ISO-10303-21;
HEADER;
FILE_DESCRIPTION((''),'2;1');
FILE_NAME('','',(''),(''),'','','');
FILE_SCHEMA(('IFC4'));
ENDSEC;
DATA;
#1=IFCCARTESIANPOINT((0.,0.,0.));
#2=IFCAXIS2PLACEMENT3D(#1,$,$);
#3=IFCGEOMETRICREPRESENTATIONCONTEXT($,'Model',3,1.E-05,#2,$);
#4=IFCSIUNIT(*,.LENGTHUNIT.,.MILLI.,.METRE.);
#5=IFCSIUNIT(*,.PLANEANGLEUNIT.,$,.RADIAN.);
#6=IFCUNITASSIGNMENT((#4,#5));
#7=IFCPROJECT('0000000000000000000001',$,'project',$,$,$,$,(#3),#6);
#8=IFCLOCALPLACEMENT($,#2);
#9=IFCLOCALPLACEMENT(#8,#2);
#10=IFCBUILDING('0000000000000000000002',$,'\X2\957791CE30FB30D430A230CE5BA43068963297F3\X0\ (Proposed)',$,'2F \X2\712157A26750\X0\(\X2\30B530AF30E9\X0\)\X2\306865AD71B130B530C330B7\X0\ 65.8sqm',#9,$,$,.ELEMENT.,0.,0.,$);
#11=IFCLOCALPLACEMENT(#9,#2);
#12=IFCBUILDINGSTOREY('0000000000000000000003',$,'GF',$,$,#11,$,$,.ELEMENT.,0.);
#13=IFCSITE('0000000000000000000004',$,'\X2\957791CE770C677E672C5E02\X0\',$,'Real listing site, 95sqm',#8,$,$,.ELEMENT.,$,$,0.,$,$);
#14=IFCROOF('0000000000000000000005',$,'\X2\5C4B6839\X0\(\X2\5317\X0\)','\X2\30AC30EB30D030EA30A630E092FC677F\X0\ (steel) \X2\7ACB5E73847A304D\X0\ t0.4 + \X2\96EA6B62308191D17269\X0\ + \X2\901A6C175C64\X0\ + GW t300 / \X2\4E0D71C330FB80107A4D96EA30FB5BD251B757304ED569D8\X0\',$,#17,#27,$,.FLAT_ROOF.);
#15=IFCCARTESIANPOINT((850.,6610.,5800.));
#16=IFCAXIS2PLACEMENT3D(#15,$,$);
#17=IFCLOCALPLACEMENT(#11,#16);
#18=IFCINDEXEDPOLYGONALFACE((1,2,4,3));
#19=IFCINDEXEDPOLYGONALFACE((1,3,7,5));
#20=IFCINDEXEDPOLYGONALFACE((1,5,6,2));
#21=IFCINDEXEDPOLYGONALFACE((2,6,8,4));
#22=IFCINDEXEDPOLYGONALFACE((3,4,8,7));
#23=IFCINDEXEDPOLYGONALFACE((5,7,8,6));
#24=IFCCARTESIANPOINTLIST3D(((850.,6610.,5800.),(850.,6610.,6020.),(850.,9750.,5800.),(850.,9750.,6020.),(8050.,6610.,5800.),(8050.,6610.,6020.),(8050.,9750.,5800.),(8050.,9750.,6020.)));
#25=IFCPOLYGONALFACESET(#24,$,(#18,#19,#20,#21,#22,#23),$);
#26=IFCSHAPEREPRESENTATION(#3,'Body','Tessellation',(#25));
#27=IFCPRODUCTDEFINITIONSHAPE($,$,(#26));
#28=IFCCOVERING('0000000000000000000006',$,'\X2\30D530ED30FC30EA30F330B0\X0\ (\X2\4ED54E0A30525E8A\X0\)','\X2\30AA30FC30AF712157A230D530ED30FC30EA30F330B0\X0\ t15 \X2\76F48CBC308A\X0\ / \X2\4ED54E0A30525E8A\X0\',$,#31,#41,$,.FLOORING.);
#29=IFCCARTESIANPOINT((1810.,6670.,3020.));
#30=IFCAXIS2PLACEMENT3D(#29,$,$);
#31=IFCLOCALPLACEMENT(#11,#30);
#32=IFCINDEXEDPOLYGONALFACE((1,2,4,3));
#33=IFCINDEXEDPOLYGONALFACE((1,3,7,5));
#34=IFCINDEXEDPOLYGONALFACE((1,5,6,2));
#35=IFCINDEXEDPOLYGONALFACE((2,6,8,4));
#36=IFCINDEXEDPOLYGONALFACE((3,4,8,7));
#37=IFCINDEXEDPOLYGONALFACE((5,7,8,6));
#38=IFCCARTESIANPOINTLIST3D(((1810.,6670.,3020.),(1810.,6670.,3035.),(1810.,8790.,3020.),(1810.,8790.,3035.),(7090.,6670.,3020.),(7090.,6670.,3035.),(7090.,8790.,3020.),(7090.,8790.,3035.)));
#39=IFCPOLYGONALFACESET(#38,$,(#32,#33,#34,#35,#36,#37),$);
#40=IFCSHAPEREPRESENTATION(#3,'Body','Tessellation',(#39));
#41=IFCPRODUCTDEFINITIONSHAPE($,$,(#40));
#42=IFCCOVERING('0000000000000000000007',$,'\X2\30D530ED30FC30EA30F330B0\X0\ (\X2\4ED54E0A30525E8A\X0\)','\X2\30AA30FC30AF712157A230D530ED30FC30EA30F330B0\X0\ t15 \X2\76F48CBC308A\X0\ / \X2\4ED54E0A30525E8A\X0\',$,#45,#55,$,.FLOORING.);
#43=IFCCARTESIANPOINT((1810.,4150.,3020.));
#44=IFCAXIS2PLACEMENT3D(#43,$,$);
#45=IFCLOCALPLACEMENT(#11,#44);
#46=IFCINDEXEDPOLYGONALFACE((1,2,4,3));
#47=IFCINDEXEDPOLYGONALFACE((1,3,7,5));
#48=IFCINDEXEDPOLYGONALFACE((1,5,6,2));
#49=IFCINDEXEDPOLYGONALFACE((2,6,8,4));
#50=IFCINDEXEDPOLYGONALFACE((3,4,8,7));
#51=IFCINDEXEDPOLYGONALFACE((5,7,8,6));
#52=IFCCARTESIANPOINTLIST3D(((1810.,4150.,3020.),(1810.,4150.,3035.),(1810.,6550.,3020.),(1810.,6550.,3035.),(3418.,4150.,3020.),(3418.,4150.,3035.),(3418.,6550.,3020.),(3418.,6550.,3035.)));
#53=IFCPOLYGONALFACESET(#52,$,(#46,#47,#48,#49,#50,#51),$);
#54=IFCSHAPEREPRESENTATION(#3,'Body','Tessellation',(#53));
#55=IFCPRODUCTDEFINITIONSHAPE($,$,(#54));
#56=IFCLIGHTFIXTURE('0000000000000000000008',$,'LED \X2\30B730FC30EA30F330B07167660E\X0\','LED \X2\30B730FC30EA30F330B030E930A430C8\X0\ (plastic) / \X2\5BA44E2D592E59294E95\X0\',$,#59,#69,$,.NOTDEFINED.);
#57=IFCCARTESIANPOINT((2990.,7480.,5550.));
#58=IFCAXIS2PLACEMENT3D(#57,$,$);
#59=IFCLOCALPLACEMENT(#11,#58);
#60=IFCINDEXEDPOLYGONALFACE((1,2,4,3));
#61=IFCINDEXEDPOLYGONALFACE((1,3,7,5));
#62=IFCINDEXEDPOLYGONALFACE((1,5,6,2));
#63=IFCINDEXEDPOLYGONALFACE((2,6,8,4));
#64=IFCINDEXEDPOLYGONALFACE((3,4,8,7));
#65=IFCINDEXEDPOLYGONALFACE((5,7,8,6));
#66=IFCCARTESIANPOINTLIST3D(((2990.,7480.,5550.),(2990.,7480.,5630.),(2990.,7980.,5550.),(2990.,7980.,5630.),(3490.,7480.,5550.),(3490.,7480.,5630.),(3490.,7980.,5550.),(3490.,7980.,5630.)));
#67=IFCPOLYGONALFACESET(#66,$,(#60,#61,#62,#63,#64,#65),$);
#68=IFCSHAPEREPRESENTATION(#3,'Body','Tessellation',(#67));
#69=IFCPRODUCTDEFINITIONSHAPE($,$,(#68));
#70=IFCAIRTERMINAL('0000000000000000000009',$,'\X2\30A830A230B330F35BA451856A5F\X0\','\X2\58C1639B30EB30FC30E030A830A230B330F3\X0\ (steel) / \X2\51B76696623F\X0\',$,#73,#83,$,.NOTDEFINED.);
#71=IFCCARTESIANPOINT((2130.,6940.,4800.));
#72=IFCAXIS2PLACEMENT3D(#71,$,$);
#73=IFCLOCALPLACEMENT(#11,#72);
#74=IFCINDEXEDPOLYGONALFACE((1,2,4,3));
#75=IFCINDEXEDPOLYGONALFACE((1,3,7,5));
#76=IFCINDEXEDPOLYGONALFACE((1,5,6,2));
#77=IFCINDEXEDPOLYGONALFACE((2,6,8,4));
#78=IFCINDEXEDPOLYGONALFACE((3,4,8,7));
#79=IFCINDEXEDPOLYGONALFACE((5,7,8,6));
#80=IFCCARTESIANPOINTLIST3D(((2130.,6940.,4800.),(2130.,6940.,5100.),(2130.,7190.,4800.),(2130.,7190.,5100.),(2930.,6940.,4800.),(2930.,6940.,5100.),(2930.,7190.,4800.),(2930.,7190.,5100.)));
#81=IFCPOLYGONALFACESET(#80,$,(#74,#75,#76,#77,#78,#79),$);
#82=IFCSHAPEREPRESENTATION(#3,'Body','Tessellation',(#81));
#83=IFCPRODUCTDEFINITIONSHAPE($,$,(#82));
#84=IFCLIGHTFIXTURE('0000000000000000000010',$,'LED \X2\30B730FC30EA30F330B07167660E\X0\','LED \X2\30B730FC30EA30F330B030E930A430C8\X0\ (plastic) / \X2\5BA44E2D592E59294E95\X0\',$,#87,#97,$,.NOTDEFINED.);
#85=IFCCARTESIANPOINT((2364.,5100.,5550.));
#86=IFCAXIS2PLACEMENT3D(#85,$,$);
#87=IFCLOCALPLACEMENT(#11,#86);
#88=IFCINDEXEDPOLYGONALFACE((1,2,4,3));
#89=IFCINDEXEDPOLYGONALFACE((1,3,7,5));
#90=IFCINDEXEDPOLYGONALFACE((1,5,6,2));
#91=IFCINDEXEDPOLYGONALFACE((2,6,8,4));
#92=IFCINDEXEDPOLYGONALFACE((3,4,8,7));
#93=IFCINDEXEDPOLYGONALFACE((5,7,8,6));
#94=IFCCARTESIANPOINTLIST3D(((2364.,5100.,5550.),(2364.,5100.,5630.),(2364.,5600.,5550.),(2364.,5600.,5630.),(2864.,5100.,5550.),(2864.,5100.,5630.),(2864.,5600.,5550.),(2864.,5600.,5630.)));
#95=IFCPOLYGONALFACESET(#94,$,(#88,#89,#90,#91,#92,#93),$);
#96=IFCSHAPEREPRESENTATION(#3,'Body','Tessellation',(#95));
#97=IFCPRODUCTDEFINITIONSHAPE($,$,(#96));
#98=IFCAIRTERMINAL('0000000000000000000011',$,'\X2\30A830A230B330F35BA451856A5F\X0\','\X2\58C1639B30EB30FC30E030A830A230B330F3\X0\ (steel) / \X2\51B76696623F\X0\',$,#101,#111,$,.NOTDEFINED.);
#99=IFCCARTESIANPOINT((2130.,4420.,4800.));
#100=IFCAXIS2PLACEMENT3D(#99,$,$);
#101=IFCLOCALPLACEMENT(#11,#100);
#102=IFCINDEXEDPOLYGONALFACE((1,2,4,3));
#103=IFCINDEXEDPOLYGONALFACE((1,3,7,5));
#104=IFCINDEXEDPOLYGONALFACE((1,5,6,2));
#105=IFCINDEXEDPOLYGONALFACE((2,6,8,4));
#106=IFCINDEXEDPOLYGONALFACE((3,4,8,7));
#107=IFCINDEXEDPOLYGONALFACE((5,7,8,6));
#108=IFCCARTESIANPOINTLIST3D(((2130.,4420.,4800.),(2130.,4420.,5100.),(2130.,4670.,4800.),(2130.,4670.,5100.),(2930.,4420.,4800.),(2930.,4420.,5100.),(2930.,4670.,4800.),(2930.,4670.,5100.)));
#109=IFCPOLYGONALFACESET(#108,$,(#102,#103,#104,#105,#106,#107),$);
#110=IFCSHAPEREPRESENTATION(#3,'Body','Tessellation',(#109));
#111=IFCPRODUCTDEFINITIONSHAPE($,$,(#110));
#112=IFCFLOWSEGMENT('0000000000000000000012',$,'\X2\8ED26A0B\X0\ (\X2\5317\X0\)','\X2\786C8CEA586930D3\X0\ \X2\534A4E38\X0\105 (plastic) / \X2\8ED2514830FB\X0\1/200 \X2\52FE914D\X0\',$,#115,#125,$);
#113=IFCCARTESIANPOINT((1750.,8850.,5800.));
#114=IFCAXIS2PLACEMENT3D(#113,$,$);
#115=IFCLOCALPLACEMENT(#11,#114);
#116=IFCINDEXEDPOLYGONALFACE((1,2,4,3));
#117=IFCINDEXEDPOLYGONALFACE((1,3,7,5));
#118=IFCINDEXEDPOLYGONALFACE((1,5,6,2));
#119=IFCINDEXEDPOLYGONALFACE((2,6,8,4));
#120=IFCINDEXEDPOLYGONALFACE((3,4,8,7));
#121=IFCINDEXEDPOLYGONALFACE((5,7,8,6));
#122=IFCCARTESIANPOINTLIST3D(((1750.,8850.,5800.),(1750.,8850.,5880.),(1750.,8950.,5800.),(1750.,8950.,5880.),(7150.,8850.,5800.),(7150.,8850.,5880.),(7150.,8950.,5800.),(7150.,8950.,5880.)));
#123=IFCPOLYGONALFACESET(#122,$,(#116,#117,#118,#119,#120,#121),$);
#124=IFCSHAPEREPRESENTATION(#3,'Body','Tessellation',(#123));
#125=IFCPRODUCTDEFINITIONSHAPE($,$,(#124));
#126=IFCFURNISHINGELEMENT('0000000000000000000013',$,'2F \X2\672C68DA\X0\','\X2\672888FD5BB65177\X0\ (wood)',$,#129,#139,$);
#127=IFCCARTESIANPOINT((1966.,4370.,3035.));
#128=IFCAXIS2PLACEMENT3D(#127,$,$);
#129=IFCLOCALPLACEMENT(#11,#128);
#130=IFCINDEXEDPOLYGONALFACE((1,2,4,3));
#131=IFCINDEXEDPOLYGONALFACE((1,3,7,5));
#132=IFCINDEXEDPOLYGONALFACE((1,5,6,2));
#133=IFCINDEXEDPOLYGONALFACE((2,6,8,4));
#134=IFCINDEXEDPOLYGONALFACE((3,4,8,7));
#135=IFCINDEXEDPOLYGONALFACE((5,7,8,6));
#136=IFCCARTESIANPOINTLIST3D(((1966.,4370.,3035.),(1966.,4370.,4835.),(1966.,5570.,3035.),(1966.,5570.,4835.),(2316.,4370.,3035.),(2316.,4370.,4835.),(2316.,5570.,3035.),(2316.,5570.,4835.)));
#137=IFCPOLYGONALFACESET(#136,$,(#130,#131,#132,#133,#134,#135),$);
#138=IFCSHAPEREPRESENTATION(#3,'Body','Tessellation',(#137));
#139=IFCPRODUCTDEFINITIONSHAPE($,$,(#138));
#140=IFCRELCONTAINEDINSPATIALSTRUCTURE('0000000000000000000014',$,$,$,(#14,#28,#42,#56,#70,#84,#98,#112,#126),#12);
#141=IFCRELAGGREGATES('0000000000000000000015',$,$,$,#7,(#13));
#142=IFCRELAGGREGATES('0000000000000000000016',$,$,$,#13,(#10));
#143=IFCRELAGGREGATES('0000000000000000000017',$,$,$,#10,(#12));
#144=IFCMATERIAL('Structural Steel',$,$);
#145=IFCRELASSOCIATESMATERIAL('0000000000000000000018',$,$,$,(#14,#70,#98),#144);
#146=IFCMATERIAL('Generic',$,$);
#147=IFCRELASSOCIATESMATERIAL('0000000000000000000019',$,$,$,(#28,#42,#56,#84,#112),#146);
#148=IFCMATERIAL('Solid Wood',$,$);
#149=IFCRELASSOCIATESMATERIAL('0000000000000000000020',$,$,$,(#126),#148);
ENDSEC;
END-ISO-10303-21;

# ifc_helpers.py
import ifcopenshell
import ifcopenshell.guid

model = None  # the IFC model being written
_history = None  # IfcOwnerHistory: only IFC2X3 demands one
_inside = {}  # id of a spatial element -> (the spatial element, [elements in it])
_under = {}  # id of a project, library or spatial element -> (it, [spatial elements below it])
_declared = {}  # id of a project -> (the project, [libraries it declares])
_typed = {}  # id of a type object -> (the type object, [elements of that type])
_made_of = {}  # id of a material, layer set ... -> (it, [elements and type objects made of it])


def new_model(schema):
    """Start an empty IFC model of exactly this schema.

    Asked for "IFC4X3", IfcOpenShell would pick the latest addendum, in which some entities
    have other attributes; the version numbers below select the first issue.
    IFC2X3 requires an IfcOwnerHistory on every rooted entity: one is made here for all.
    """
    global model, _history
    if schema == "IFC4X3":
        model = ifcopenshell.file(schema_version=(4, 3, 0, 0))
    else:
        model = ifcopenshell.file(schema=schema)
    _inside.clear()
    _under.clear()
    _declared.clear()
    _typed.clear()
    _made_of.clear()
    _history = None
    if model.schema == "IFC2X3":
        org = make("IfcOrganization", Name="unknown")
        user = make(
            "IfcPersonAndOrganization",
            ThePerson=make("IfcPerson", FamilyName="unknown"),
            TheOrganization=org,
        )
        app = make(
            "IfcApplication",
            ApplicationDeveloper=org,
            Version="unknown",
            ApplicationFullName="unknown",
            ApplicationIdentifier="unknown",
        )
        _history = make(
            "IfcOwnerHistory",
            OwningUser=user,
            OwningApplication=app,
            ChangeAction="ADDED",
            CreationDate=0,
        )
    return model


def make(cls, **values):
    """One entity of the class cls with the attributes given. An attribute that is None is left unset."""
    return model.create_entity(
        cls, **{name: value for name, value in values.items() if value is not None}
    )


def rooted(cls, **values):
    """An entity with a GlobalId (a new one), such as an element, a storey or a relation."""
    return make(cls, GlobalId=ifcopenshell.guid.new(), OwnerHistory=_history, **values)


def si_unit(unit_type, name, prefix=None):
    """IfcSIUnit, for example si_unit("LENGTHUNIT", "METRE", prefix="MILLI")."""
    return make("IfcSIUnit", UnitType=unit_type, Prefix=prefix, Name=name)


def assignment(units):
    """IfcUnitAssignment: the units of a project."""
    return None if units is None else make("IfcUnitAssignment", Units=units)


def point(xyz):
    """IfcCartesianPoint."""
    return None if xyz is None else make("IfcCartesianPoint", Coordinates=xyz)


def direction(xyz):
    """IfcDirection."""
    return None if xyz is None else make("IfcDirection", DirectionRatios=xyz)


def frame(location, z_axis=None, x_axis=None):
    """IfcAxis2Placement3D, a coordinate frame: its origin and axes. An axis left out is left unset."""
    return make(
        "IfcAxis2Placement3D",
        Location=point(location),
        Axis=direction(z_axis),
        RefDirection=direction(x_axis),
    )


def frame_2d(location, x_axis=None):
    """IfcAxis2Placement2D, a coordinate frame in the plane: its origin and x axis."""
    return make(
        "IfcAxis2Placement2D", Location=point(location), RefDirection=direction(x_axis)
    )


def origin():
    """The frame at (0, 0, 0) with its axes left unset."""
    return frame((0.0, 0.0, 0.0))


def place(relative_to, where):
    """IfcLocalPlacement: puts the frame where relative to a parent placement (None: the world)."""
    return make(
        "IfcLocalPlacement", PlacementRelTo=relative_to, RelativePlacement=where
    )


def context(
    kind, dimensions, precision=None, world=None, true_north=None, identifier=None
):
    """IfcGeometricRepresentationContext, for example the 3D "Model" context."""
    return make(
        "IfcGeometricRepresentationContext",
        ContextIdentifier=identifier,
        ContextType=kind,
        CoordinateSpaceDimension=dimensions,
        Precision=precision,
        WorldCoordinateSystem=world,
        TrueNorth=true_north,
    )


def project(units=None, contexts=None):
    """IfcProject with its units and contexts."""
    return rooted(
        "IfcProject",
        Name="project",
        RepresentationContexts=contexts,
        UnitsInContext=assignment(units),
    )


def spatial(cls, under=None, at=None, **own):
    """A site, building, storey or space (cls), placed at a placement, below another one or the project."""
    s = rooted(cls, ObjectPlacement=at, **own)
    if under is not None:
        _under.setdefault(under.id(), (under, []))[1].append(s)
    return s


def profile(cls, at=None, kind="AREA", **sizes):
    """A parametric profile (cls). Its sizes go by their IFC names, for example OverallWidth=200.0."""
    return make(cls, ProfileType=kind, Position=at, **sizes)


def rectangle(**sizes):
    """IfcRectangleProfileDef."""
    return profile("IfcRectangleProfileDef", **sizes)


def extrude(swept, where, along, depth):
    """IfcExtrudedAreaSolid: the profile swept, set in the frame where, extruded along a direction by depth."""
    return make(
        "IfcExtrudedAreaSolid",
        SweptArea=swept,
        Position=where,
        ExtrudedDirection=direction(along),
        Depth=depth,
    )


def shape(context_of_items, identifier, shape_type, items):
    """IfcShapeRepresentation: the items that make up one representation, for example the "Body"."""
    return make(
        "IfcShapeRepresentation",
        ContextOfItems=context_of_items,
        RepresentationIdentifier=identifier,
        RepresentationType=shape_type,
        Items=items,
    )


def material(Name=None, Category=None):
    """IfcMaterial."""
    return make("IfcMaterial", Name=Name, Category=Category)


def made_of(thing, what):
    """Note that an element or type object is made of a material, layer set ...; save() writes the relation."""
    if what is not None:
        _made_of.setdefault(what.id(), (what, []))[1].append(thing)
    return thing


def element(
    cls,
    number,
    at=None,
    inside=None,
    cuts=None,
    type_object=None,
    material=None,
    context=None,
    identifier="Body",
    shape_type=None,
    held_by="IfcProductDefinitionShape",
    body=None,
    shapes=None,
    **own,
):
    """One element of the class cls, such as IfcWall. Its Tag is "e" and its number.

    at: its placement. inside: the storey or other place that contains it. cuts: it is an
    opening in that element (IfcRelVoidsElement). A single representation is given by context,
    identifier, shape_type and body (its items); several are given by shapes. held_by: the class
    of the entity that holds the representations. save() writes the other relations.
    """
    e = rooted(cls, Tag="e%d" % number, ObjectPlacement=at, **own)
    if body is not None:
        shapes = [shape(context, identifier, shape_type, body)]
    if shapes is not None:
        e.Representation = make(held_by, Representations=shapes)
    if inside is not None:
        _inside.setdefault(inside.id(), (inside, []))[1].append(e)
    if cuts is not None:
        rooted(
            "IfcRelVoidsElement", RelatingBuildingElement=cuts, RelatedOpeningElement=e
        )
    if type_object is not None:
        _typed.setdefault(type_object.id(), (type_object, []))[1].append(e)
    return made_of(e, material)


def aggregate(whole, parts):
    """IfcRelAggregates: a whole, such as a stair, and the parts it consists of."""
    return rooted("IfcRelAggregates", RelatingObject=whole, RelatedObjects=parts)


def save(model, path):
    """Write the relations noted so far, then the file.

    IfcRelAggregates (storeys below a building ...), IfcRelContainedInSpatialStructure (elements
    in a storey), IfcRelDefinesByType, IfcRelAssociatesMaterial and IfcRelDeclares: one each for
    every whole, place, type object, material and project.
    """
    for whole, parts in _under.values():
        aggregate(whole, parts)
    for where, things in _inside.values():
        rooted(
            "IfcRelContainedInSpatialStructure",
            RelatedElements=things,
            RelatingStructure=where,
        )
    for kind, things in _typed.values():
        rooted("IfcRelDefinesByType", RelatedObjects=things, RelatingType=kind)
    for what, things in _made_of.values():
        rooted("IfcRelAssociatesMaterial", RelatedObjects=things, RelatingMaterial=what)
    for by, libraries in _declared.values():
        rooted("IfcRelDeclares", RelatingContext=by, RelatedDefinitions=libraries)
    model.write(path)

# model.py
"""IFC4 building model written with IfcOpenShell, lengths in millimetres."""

from ifc_helpers import new_model, si_unit, frame, frame_2d, origin, place, context, project, spatial, rectangle, extrude, material, element, save


model = new_model("IFC4")

# Units and contexts
model_context = context("Model", 3, precision=1e-05, world=origin())
ifc_project = project(units=[si_unit("LENGTHUNIT", "METRE", prefix="MILLI"), si_unit("PLANEANGLEUNIT", "RADIAN")], contexts=[model_context])

# Site, building, storey
site_placement = place(None, origin())
site = spatial("IfcSite", under=ifc_project, at=site_placement, Name="長野県松本市", ObjectType="Real listing site, 95sqm", CompositionType="ELEMENT", RefElevation=0.0)
building_placement = place(site_placement, origin())
building = spatial("IfcBuilding", under=site, at=building_placement, Name="長野・ピアノ室と防音 (Proposed)", ObjectType="2F 無垢材(サクラ)と断熱サッシ 65.8sqm", CompositionType="ELEMENT", ElevationOfRefHeight=0.0, ElevationOfTerrain=0.0)
storey_placement = place(building_placement, origin())
storey = spatial("IfcBuildingStorey", under=building, at=storey_placement, Name="GF", CompositionType="ELEMENT", Elevation=0.0)

# Shared definitions
ifc_material_1 = material(Name="Solid Wood")

# Roof
ifc_material_2 = material(Name="Structural Steel")
for number, where, name in (
    (1, (850.0, 6610.0, 5800.0), "屋根(北)"),
):
    element("IfcRoof", number, at=place(storey_placement, frame(where)), inside=storey, material=ifc_material_2, Name=name, Description="ガルバリウム鋼板 (steel) 立平葺き t0.4 + 雪止め金物 + 通気層 + GW t300 / 不燃・耐積雪・寒冷地仕様", PredefinedType="FLAT_ROOF", context=model_context, shape_type="SweptSolid", body=[
        extrude(rectangle(XDim=7200.0, YDim=3140.0, at=frame_2d((3600.0, 1570.0))), frame((850.0, 6610.0, 5800.0)), (0.0, 0.0, 1.0), 220.0),
    ])

# Coverings
ifc_material_3 = material(Name="Generic")
covering_1_placement = place(storey_placement, frame((1810.0, 6670.0, 3020.0)))
element("IfcCovering", 2, at=covering_1_placement, inside=storey, material=ifc_material_3, Name="フローリング (仕上げ床)", Description="オーク無垢フローリング t15 直貼り / 仕上げ床", PredefinedType="FLOORING", context=model_context, shape_type="SweptSolid", body=[
    extrude(rectangle(XDim=5280.0, YDim=2120.0, at=frame_2d((2640.0, 1060.0))), frame((1810.0, 6670.0, 3020.0)), (0.0, 0.0, 1.0), 15.0),
])
covering_2_placement = place(storey_placement, frame((1810.0, 4150.0, 3020.0)))
element("IfcCovering", 3, at=covering_2_placement, inside=storey, material=ifc_material_3, Name="フローリング (仕上げ床)", Description="オーク無垢フローリング t15 直貼り / 仕上げ床", PredefinedType="FLOORING", context=model_context, shape_type="SweptSolid", body=[
    extrude(rectangle(XDim=1608.0, YDim=2400.0, at=frame_2d((804.0, 1200.0))), frame((1810.0, 4150.0, 3020.0)), (0.0, 0.0, 1.0), 15.0),
])

# Light fixture
light_fixture_1_placement = place(storey_placement, frame((2990.0, 7480.0, 5550.0)))
element("IfcLightFixture", 4, at=light_fixture_1_placement, inside=storey, material=ifc_material_3, Name="LED シーリング照明", Description="LED シーリングライト (plastic) / 室中央天井", PredefinedType="NOTDEFINED", context=model_context, shape_type="SweptSolid", body=[
    extrude(rectangle(XDim=500.0, YDim=500.0, at=frame_2d((250.0, 250.0))), frame((2990.0, 7480.0, 5550.0)), (0.0, 0.0, 1.0), 80.0),
])

# Air terminal
air_terminal_1_placement = place(storey_placement, frame((2130.0, 6940.0, 4800.0)))
element("IfcAirTerminal", 5, at=air_terminal_1_placement, inside=storey, material=ifc_material_2, Name="エアコン室内機", Description="壁掛ルームエアコン (steel) / 冷暖房", PredefinedType="NOTDEFINED", context=model_context, shape_type="SweptSolid", body=[
    extrude(rectangle(XDim=800.0, YDim=250.0, at=frame_2d((400.0, 125.0))), frame((2130.0, 6940.0, 4800.0)), (0.0, 0.0, 1.0), 300.0),
])

# Light fixture
light_fixture_2_placement = place(storey_placement, frame((2364.0, 5100.0, 5550.0)))
element("IfcLightFixture", 6, at=light_fixture_2_placement, inside=storey, material=ifc_material_3, Name="LED シーリング照明", Description="LED シーリングライト (plastic) / 室中央天井", PredefinedType="NOTDEFINED", context=model_context, shape_type="SweptSolid", body=[
    extrude(rectangle(XDim=500.0, YDim=500.0, at=frame_2d((250.0, 250.0))), frame((2364.0, 5100.0, 5550.0)), (0.0, 0.0, 1.0), 80.0),
])

# Air terminal
air_terminal_2_placement = place(storey_placement, frame((2130.0, 4420.0, 4800.0)))
element("IfcAirTerminal", 7, at=air_terminal_2_placement, inside=storey, material=ifc_material_2, Name="エアコン室内機", Description="壁掛ルームエアコン (steel) / 冷暖房", PredefinedType="NOTDEFINED", context=model_context, shape_type="SweptSolid", body=[
    extrude(rectangle(XDim=800.0, YDim=250.0, at=frame_2d((400.0, 125.0))), frame((2130.0, 4420.0, 4800.0)), (0.0, 0.0, 1.0), 300.0),
])

# Flow segment
flow_segment_placement = place(storey_placement, frame((1750.0, 8850.0, 5800.0)))
element("IfcFlowSegment", 8, at=flow_segment_placement, inside=storey, material=ifc_material_3, Name="軒樋 (北)", Description="硬質塩ビ 半丸105 (plastic) / 軒先・1/200 勾配", context=model_context, shape_type="SweptSolid", body=[
    extrude(rectangle(XDim=5400.0, YDim=100.0, at=frame_2d((2700.0, 50.0))), frame((1750.0, 8850.0, 5800.0)), (0.0, 0.0, 1.0), 80.0),
])

# Furnishing element
furnishing_placement = place(storey_placement, frame((1966.0, 4370.0, 3035.0)))
element("IfcFurnishingElement", 9, at=furnishing_placement, inside=storey, material=ifc_material_1, Name="2F 本棚", Description="木製家具 (wood)", context=model_context, shape_type="SweptSolid", body=[
    extrude(rectangle(XDim=350.0, YDim=1200.0, at=frame_2d((175.0, 600.0))), frame((1966.0, 4370.0, 3035.0)), (0.0, 0.0, 1.0), 1800.0),
])

save(model, "model.ifc")
